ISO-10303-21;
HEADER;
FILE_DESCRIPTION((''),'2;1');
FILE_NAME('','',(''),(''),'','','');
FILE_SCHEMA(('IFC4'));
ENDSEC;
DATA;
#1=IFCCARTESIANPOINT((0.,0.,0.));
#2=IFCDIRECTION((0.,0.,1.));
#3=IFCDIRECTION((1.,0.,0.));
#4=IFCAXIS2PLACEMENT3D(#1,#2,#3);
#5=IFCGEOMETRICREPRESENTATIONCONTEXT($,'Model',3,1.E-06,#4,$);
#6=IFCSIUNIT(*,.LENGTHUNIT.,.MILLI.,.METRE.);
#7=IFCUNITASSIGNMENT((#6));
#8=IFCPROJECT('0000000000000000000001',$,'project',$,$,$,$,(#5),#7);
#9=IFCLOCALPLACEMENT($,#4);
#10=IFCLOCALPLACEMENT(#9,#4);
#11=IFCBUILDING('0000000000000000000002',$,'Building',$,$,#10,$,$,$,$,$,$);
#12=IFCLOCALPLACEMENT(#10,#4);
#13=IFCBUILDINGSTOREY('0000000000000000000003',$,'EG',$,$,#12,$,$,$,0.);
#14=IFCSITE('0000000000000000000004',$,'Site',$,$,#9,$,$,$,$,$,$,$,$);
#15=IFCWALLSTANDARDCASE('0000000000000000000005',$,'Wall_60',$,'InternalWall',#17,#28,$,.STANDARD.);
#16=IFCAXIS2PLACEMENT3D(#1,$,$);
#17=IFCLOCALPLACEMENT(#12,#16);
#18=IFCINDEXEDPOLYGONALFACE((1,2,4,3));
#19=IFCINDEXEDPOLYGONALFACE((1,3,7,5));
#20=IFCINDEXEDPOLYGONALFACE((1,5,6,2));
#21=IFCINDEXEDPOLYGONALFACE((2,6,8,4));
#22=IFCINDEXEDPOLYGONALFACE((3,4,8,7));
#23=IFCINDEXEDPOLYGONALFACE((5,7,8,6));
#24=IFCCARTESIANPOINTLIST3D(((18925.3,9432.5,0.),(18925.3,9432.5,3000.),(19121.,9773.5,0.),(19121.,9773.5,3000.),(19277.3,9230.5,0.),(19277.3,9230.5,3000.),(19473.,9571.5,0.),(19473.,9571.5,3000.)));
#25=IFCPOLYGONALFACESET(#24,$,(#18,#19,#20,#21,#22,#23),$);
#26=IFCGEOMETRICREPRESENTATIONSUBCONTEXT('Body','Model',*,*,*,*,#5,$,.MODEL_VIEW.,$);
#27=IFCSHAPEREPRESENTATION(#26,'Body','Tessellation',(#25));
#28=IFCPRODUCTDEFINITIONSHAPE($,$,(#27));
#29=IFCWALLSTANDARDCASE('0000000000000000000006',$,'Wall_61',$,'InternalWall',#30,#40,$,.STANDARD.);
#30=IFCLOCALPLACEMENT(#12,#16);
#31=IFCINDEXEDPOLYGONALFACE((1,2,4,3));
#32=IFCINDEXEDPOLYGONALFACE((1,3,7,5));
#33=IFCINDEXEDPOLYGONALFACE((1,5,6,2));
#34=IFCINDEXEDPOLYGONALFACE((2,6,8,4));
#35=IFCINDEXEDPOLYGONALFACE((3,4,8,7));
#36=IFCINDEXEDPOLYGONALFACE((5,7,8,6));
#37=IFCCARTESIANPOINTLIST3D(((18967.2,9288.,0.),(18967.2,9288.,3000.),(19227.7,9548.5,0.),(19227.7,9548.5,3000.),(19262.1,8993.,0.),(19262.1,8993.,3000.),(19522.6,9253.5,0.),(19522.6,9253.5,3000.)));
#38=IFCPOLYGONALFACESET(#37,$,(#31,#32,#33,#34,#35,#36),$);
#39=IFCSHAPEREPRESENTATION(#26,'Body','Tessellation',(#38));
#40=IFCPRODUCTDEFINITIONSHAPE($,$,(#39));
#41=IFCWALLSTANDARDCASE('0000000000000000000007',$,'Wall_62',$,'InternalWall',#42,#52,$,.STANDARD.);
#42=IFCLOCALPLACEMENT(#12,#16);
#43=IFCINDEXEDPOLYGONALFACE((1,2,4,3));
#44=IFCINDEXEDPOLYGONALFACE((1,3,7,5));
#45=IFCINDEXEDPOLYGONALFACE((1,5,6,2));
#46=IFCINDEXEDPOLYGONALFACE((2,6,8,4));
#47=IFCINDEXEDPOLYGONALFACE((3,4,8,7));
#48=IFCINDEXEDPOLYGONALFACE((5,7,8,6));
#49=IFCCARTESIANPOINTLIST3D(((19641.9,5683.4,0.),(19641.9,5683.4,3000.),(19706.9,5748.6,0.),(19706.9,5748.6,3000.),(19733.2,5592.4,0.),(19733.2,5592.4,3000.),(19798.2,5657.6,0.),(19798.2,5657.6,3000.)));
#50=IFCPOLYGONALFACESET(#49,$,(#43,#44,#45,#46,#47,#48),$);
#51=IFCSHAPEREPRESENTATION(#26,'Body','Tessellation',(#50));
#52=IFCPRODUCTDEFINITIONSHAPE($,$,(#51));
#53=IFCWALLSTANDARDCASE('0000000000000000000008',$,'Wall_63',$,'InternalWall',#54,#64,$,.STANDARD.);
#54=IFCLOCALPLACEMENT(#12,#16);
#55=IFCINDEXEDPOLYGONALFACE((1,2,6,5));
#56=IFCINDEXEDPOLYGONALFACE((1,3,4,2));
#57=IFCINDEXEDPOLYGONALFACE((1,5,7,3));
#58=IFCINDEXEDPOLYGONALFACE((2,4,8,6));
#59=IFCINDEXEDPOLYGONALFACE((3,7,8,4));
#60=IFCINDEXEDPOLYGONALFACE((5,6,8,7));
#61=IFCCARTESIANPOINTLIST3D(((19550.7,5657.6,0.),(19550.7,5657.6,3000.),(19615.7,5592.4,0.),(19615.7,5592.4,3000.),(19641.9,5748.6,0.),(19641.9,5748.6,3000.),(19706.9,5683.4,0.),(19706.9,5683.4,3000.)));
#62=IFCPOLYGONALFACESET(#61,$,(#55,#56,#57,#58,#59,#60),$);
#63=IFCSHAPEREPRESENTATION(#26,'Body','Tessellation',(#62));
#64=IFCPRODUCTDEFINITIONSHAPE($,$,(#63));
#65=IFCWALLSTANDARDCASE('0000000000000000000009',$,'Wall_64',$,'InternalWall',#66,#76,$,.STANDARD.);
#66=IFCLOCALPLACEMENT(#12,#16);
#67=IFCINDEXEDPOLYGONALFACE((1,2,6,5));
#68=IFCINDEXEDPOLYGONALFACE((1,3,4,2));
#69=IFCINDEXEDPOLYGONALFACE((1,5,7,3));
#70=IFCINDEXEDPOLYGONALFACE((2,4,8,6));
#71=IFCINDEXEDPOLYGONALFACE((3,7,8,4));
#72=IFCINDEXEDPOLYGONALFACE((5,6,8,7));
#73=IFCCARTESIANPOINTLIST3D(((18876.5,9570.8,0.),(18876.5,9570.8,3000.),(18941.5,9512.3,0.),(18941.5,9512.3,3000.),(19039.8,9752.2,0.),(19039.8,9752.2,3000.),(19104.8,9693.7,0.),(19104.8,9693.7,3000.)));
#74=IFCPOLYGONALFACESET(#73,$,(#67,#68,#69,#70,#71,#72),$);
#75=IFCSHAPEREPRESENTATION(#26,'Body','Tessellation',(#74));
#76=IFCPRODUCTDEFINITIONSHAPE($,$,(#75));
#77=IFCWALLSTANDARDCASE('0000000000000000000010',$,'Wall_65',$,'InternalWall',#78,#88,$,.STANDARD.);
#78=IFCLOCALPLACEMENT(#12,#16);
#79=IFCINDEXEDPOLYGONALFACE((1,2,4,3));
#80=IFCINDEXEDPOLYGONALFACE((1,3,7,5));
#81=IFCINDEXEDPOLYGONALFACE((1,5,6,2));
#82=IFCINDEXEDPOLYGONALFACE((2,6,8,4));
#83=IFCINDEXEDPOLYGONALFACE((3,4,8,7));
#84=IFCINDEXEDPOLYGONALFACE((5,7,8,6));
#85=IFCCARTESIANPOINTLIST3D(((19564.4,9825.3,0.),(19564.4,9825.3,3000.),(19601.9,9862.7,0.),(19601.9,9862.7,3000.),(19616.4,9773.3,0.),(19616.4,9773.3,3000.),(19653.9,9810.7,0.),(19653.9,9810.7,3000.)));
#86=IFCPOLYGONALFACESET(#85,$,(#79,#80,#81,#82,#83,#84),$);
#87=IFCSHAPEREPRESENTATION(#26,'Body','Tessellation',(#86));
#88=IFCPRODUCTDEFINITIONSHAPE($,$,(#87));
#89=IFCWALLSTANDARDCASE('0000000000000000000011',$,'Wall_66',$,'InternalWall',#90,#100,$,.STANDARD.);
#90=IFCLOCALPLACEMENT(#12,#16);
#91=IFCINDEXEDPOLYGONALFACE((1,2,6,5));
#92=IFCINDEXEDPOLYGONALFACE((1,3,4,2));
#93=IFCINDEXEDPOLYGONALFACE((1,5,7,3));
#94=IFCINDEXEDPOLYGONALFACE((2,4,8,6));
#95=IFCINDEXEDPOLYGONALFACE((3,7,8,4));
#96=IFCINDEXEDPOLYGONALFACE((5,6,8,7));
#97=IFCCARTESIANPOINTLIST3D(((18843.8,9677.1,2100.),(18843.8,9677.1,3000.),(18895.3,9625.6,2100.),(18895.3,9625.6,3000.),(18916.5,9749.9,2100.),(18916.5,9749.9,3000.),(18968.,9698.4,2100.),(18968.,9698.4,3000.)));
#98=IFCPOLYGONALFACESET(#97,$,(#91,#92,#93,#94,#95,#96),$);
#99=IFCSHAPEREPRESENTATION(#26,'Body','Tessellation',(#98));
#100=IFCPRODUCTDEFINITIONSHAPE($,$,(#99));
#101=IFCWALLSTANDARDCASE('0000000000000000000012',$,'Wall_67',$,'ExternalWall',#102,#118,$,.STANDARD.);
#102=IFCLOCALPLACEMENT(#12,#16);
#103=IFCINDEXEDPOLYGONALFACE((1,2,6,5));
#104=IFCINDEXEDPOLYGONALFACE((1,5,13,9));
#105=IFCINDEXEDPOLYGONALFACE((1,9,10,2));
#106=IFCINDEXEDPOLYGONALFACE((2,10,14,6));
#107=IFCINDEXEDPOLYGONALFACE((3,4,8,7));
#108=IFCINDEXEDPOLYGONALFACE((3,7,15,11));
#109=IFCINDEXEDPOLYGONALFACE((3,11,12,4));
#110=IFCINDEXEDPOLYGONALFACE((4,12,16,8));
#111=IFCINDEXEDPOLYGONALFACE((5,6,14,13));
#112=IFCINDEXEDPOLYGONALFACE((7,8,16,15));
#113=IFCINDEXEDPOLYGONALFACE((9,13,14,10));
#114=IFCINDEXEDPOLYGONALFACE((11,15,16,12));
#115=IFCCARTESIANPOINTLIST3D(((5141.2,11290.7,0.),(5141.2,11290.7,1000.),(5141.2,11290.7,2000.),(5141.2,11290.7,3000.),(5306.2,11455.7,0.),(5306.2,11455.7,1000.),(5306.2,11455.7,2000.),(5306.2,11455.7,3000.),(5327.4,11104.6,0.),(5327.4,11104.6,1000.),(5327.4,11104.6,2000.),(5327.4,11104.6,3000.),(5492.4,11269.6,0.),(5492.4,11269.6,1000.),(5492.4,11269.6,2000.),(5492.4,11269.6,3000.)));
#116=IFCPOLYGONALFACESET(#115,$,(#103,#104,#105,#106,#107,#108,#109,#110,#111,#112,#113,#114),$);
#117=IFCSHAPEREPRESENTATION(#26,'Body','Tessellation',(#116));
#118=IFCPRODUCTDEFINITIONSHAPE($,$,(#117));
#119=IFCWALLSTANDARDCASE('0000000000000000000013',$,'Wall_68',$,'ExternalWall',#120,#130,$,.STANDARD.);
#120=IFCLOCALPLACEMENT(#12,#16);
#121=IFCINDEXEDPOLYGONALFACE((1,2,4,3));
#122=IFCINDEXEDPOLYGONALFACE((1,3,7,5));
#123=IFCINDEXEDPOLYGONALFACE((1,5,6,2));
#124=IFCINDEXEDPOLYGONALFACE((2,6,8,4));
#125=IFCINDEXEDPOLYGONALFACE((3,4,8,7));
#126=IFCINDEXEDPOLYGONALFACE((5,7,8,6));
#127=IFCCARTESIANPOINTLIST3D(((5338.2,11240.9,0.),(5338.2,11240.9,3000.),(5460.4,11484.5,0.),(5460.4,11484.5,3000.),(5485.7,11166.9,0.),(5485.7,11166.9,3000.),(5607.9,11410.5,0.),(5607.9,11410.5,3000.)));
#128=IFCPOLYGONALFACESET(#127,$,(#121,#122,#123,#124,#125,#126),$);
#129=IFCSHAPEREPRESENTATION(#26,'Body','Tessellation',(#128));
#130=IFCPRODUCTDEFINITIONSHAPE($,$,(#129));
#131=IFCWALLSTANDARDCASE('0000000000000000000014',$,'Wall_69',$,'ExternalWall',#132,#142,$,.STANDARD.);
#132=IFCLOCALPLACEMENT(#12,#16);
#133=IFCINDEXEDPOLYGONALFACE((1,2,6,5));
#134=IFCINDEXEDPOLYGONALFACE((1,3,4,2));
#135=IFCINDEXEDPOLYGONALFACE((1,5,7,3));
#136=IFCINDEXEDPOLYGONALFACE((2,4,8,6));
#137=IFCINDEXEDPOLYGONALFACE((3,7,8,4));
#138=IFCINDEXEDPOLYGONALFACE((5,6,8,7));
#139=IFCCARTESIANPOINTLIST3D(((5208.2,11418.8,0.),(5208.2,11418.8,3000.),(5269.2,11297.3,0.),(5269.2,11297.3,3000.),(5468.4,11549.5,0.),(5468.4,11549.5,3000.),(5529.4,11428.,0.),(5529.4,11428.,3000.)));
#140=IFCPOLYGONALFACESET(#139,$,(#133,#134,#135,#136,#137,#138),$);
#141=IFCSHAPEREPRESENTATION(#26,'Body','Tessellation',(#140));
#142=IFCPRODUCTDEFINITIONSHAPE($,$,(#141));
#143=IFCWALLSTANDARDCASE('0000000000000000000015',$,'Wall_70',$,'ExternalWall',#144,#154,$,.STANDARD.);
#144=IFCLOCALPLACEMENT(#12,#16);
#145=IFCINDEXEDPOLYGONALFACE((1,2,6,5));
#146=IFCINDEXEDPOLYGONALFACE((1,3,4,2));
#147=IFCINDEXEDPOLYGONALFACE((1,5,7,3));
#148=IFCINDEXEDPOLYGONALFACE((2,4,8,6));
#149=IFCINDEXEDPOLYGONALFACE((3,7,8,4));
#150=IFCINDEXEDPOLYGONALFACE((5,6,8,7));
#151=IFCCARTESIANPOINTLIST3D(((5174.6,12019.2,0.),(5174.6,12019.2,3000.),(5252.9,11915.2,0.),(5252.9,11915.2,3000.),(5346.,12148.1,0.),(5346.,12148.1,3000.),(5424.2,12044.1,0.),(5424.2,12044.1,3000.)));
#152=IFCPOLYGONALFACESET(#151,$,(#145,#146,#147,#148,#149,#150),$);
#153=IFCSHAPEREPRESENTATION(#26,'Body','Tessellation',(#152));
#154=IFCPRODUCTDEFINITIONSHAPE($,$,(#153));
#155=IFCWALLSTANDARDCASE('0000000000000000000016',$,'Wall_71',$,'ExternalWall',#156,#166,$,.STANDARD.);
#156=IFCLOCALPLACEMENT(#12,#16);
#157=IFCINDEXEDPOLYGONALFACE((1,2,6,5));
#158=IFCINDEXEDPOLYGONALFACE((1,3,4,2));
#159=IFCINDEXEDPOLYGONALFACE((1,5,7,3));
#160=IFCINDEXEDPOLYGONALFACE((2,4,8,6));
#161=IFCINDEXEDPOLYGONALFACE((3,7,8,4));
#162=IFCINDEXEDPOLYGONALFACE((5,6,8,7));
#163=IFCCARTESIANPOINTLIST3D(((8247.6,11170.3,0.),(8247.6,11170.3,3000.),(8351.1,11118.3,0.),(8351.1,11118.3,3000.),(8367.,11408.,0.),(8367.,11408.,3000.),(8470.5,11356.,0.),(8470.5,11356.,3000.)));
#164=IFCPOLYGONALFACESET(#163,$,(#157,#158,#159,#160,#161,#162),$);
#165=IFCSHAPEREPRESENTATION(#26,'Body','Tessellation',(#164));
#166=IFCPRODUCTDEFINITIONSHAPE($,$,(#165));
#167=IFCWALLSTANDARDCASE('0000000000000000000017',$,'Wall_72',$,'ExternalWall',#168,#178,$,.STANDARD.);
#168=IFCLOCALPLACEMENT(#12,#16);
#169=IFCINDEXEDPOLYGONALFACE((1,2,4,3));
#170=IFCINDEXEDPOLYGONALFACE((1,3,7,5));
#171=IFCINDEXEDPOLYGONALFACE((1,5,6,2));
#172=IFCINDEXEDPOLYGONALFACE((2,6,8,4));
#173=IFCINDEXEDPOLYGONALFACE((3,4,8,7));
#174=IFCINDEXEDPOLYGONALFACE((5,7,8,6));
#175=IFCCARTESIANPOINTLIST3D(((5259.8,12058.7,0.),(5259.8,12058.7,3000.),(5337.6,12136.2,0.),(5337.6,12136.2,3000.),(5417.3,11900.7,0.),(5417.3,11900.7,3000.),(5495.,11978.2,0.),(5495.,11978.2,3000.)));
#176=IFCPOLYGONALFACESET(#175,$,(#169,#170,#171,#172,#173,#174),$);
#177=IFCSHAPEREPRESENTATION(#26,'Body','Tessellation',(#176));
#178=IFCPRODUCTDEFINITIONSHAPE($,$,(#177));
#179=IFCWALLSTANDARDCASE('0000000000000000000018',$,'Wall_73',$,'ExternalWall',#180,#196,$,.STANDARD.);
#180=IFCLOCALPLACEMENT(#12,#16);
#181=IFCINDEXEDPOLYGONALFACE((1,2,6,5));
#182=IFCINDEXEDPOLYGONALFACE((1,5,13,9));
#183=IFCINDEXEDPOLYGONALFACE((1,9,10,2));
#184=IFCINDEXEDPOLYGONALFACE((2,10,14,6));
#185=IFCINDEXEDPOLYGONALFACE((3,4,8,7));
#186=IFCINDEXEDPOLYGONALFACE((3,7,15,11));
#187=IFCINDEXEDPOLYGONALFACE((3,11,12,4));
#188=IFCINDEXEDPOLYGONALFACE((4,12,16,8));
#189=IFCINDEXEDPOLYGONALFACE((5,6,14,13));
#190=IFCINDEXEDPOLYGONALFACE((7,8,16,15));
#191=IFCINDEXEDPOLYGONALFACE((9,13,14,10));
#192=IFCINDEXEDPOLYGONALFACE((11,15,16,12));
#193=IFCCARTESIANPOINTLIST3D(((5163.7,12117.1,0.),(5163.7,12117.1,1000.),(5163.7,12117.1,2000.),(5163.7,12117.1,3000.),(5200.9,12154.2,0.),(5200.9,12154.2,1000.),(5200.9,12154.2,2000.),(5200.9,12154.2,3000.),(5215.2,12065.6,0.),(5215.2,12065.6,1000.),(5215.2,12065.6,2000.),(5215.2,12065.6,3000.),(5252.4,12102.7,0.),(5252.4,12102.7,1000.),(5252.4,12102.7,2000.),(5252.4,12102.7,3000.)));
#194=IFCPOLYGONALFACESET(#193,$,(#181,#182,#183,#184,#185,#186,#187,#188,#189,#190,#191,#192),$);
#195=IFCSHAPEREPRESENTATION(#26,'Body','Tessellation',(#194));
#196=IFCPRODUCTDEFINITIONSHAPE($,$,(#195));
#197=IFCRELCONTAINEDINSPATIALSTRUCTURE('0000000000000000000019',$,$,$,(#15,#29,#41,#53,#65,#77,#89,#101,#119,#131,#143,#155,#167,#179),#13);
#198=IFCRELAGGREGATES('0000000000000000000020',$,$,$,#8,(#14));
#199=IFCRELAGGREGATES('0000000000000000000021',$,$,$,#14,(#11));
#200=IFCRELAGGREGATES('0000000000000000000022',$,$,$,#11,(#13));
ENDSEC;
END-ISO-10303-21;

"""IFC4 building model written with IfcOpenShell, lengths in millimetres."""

from ifc_helpers import new_model, si_unit, frame, origin_with_axes, place, context, subcontext, project, spatial, rectangle, extrude, element, save


model = new_model("IFC4")

# Units and contexts
model_context = context("Model", 3, precision=1e-06, world=origin_with_axes())
body_context = subcontext(model_context, "Body", "Model", "MODEL_VIEW")
ifc_project = project(units=[si_unit("LENGTHUNIT", "METRE", prefix="MILLI")], contexts=[model_context])

# Site, building, storey
site_placement = place(None, origin_with_axes())
site = spatial("IfcSite", under=ifc_project, at=site_placement, Name="Site")
building_placement = place(site_placement, origin_with_axes())
building = spatial("IfcBuilding", under=site, at=building_placement, Name="Building")
storey_placement = place(building_placement, origin_with_axes())
storey = spatial("IfcBuildingStorey", under=building, at=storey_placement, Name="EG", Elevation=0.0)

# Walls
wall_1_placement = place(storey_placement, origin_with_axes())
element("IfcWallStandardCase", 1, at=wall_1_placement, inside=storey, Name="Wall_60", ObjectType="InternalWall", PredefinedType="STANDARD", context=body_context, shape_type="SweptSolid", body=[
    extrude(rectangle(XDim=405.8, YDim=393.1), frame((19199.2, 9502.0, 0.0), z_axis=(0.0, 0.0, 1.0), x_axis=(-0.867332, 0.49773, 0.0)), (0.0, 0.0, 1.0), 3000.0),
])
wall_2_placement = place(storey_placement, origin_with_axes())
element("IfcWallStandardCase", 2, at=wall_2_placement, inside=storey, Name="Wall_61", ObjectType="InternalWall", PredefinedType="STANDARD", context=body_context, shape_type="SweptSolid", body=[
    extrude(rectangle(XDim=368.4, YDim=417.1), frame((19244.9, 9270.8, 0.0), z_axis=(0.0, 0.0, 1.0), x_axis=(-0.707107, -0.707107, 0.0)), (0.0, 0.0, 1.0), 3000.0),
])
wall_3_placement = place(storey_placement, origin_with_axes())
element("IfcWallStandardCase", 3, at=wall_3_placement, inside=storey, Name="Wall_62", ObjectType="InternalWall", PredefinedType="STANDARD", context=body_context, shape_type="SweptSolid", body=[
    extrude(rectangle(XDim=128.9, YDim=92.0), frame((19720.0, 5670.5, 0.0), z_axis=(0.0, 0.0, 1.0), x_axis=(0.708076, -0.706136, 0.0)), (0.0, 0.0, 1.0), 3000.0),
])
wall_4_placement = place(storey_placement, origin_with_axes())
element("IfcWallStandardCase", 4, at=wall_4_placement, inside=storey, Name="Wall_63", ObjectType="InternalWall", PredefinedType="STANDARD", context=body_context, shape_type="SweptSolid", body=[
    extrude(rectangle(XDim=128.9, YDim=92.0), frame((19628.8, 5670.5, 0.0), z_axis=(0.0, 0.0, 1.0), x_axis=(-0.708076, -0.706136, 0.0)), (0.0, 0.0, 1.0), 3000.0),
])
wall_5_placement = place(storey_placement, origin_with_axes())
element("IfcWallStandardCase", 5, at=wall_5_placement, inside=storey, Name="Wall_64", ObjectType="InternalWall", PredefinedType="STANDARD", context=body_context, shape_type="SweptSolid", body=[
    extrude(rectangle(XDim=87.4, YDim=244.0), frame((18990.7, 9632.3, 0.0), z_axis=(0.0, 0.0, 1.0), x_axis=(-0.743294, 0.668965, 0.0)), (0.0, 0.0, 1.0), 3000.0),
])
wall_6_placement = place(storey_placement, origin_with_axes())
element("IfcWallStandardCase", 6, at=wall_6_placement, inside=storey, Name="Wall_65", ObjectType="InternalWall", PredefinedType="STANDARD", context=body_context, shape_type="SweptSolid", body=[
    extrude(rectangle(XDim=73.5, YDim=53.0), frame((19609.2, 9818.0, 0.0), z_axis=(0.0, 0.0, 1.0), x_axis=(0.707107, -0.707107, 0.0)), (0.0, 0.0, 1.0), 3000.0),
])

# Walls, openings
wall_7_placement = place(storey_placement, origin_with_axes())
wall_7 = element("IfcWallStandardCase", 7, at=wall_7_placement, inside=storey, Name="Wall_66", ObjectType="InternalWall", PredefinedType="STANDARD", context=body_context, shape_type="SweptSolid", body=[
    extrude(rectangle(XDim=72.8, YDim=102.9), frame((18905.9, 9687.8, 0.0), z_axis=(0.0, 0.0, 1.0), x_axis=(0.707107, -0.707107, 0.0)), (0.0, 0.0, 1.0), 3000.0),
])
opening_1_placement = place(wall_7_placement, origin_with_axes())
element("IfcOpeningElement", 8, at=opening_1_placement, inside=storey, cuts=wall_7, context=body_context, shape_type="SweptSolid", body=[
    extrude(rectangle(XDim=450.0, YDim=102.9), frame((18905.9, 9687.8, 0.0), z_axis=(0.0, 0.0, 1.0), x_axis=(0.707107, -0.707107, 0.0)), (0.0, 0.0, 1.0), 2100.0),
])
wall_8_placement = place(storey_placement, origin_with_axes())
wall_8 = element("IfcWallStandardCase", 9, at=wall_8_placement, inside=storey, Name="Wall_67", ObjectType="ExternalWall", PredefinedType="STANDARD", context=body_context, shape_type="SweptSolid", body=[
    extrude(rectangle(XDim=233.3, YDim=263.3), frame((5316.8, 11280.2, 0.0), z_axis=(0.0, 0.0, 1.0), x_axis=(-0.707107, -0.707107, 0.0)), (0.0, 0.0, 1.0), 3000.0),
])
opening_2_placement = place(wall_8_placement, origin_with_axes())
element("IfcOpeningElement", 10, at=opening_2_placement, inside=storey, cuts=wall_8, context=body_context, shape_type="SweptSolid", body=[
    extrude(rectangle(XDim=600.0, YDim=263.3), frame((5253.9, 11217.3, 1000.0), z_axis=(0.0, 0.0, 1.0), x_axis=(-0.707107, -0.707107, 0.0)), (0.0, 0.0, 1.0), 1000.0),
])

# Walls
wall_9_placement = place(storey_placement, origin_with_axes())
element("IfcWallStandardCase", 11, at=wall_9_placement, inside=storey, Name="Wall_68", ObjectType="ExternalWall", PredefinedType="STANDARD", context=body_context, shape_type="SweptSolid", body=[
    extrude(rectangle(XDim=165.0, YDim=272.5), frame((5473.0, 11325.7, 0.0), z_axis=(0.0, 0.0, 1.0), x_axis=(0.89382, -0.448425, 0.0)), (0.0, 0.0, 1.0), 3000.0),
])
wall_10_placement = place(storey_placement, origin_with_axes())
element("IfcWallStandardCase", 12, at=wall_10_placement, inside=storey, Name="Wall_69", ObjectType="ExternalWall", PredefinedType="STANDARD", context=body_context, shape_type="SweptSolid", body=[
    extrude(rectangle(XDim=136.0, YDim=291.2), frame((5368.8, 11423.4, 0.0), z_axis=(0.0, 0.0, 1.0), x_axis=(0.448684, -0.89369, 0.0)), (0.0, 0.0, 1.0), 3000.0),
])
wall_11_placement = place(storey_placement, origin_with_axes())
element("IfcWallStandardCase", 13, at=wall_11_placement, inside=storey, Name="Wall_70", ObjectType="ExternalWall", PredefinedType="STANDARD", context=body_context, shape_type="SweptSolid", body=[
    extrude(rectangle(XDim=130.2, YDim=214.5), frame((5299.4, 12031.7, 0.0), z_axis=(0.0, 0.0, 1.0), x_axis=(-0.601229, 0.799077, 0.0)), (0.0, 0.0, 1.0), 3000.0),
])
wall_12_placement = place(storey_placement, origin_with_axes())
element("IfcWallStandardCase", 14, at=wall_12_placement, inside=storey, Name="Wall_71", ObjectType="ExternalWall", PredefinedType="STANDARD", context=body_context, shape_type="SweptSolid", body=[
    extrude(rectangle(XDim=115.8, YDim=266.0), frame((8359.0, 11263.2, 0.0), z_axis=(0.0, 0.0, 1.0), x_axis=(0.893562, -0.448939, 0.0)), (0.0, 0.0, 1.0), 3000.0),
])
wall_13_placement = place(storey_placement, origin_with_axes())
element("IfcWallStandardCase", 15, at=wall_13_placement, inside=storey, Name="Wall_72", ObjectType="ExternalWall", PredefinedType="STANDARD", context=body_context, shape_type="SweptSolid", body=[
    extrude(rectangle(XDim=109.8, YDim=223.1), frame((5377.4, 12018.4, 0.0), z_axis=(0.0, 0.0, 1.0), x_axis=(0.708245, 0.705967, 0.0)), (0.0, 0.0, 1.0), 3000.0),
])

# Wall, opening
wall_14_placement = place(storey_placement, origin_with_axes())
wall_14 = element("IfcWallStandardCase", 16, at=wall_14_placement, inside=storey, Name="Wall_73", ObjectType="ExternalWall", PredefinedType="STANDARD", context=body_context, shape_type="SweptSolid", body=[
    extrude(rectangle(XDim=72.8, YDim=52.5), frame((5208.0, 12109.9, 0.0), z_axis=(0.0, 0.0, 1.0), x_axis=(0.707107, -0.707107, 0.0)), (0.0, 0.0, 1.0), 3000.0),
])
opening_3_placement = place(wall_14_placement, origin_with_axes())
element("IfcOpeningElement", 17, at=opening_3_placement, inside=storey, cuts=wall_14, context=body_context, shape_type="SweptSolid", body=[
    extrude(rectangle(XDim=600.0, YDim=52.5), frame((5208.0, 12109.9, 1000.0), z_axis=(0.0, 0.0, 1.0), x_axis=(0.707107, -0.707107, 0.0)), (0.0, 0.0, 1.0), 1000.0),
])

save(model, "model.ifc")
